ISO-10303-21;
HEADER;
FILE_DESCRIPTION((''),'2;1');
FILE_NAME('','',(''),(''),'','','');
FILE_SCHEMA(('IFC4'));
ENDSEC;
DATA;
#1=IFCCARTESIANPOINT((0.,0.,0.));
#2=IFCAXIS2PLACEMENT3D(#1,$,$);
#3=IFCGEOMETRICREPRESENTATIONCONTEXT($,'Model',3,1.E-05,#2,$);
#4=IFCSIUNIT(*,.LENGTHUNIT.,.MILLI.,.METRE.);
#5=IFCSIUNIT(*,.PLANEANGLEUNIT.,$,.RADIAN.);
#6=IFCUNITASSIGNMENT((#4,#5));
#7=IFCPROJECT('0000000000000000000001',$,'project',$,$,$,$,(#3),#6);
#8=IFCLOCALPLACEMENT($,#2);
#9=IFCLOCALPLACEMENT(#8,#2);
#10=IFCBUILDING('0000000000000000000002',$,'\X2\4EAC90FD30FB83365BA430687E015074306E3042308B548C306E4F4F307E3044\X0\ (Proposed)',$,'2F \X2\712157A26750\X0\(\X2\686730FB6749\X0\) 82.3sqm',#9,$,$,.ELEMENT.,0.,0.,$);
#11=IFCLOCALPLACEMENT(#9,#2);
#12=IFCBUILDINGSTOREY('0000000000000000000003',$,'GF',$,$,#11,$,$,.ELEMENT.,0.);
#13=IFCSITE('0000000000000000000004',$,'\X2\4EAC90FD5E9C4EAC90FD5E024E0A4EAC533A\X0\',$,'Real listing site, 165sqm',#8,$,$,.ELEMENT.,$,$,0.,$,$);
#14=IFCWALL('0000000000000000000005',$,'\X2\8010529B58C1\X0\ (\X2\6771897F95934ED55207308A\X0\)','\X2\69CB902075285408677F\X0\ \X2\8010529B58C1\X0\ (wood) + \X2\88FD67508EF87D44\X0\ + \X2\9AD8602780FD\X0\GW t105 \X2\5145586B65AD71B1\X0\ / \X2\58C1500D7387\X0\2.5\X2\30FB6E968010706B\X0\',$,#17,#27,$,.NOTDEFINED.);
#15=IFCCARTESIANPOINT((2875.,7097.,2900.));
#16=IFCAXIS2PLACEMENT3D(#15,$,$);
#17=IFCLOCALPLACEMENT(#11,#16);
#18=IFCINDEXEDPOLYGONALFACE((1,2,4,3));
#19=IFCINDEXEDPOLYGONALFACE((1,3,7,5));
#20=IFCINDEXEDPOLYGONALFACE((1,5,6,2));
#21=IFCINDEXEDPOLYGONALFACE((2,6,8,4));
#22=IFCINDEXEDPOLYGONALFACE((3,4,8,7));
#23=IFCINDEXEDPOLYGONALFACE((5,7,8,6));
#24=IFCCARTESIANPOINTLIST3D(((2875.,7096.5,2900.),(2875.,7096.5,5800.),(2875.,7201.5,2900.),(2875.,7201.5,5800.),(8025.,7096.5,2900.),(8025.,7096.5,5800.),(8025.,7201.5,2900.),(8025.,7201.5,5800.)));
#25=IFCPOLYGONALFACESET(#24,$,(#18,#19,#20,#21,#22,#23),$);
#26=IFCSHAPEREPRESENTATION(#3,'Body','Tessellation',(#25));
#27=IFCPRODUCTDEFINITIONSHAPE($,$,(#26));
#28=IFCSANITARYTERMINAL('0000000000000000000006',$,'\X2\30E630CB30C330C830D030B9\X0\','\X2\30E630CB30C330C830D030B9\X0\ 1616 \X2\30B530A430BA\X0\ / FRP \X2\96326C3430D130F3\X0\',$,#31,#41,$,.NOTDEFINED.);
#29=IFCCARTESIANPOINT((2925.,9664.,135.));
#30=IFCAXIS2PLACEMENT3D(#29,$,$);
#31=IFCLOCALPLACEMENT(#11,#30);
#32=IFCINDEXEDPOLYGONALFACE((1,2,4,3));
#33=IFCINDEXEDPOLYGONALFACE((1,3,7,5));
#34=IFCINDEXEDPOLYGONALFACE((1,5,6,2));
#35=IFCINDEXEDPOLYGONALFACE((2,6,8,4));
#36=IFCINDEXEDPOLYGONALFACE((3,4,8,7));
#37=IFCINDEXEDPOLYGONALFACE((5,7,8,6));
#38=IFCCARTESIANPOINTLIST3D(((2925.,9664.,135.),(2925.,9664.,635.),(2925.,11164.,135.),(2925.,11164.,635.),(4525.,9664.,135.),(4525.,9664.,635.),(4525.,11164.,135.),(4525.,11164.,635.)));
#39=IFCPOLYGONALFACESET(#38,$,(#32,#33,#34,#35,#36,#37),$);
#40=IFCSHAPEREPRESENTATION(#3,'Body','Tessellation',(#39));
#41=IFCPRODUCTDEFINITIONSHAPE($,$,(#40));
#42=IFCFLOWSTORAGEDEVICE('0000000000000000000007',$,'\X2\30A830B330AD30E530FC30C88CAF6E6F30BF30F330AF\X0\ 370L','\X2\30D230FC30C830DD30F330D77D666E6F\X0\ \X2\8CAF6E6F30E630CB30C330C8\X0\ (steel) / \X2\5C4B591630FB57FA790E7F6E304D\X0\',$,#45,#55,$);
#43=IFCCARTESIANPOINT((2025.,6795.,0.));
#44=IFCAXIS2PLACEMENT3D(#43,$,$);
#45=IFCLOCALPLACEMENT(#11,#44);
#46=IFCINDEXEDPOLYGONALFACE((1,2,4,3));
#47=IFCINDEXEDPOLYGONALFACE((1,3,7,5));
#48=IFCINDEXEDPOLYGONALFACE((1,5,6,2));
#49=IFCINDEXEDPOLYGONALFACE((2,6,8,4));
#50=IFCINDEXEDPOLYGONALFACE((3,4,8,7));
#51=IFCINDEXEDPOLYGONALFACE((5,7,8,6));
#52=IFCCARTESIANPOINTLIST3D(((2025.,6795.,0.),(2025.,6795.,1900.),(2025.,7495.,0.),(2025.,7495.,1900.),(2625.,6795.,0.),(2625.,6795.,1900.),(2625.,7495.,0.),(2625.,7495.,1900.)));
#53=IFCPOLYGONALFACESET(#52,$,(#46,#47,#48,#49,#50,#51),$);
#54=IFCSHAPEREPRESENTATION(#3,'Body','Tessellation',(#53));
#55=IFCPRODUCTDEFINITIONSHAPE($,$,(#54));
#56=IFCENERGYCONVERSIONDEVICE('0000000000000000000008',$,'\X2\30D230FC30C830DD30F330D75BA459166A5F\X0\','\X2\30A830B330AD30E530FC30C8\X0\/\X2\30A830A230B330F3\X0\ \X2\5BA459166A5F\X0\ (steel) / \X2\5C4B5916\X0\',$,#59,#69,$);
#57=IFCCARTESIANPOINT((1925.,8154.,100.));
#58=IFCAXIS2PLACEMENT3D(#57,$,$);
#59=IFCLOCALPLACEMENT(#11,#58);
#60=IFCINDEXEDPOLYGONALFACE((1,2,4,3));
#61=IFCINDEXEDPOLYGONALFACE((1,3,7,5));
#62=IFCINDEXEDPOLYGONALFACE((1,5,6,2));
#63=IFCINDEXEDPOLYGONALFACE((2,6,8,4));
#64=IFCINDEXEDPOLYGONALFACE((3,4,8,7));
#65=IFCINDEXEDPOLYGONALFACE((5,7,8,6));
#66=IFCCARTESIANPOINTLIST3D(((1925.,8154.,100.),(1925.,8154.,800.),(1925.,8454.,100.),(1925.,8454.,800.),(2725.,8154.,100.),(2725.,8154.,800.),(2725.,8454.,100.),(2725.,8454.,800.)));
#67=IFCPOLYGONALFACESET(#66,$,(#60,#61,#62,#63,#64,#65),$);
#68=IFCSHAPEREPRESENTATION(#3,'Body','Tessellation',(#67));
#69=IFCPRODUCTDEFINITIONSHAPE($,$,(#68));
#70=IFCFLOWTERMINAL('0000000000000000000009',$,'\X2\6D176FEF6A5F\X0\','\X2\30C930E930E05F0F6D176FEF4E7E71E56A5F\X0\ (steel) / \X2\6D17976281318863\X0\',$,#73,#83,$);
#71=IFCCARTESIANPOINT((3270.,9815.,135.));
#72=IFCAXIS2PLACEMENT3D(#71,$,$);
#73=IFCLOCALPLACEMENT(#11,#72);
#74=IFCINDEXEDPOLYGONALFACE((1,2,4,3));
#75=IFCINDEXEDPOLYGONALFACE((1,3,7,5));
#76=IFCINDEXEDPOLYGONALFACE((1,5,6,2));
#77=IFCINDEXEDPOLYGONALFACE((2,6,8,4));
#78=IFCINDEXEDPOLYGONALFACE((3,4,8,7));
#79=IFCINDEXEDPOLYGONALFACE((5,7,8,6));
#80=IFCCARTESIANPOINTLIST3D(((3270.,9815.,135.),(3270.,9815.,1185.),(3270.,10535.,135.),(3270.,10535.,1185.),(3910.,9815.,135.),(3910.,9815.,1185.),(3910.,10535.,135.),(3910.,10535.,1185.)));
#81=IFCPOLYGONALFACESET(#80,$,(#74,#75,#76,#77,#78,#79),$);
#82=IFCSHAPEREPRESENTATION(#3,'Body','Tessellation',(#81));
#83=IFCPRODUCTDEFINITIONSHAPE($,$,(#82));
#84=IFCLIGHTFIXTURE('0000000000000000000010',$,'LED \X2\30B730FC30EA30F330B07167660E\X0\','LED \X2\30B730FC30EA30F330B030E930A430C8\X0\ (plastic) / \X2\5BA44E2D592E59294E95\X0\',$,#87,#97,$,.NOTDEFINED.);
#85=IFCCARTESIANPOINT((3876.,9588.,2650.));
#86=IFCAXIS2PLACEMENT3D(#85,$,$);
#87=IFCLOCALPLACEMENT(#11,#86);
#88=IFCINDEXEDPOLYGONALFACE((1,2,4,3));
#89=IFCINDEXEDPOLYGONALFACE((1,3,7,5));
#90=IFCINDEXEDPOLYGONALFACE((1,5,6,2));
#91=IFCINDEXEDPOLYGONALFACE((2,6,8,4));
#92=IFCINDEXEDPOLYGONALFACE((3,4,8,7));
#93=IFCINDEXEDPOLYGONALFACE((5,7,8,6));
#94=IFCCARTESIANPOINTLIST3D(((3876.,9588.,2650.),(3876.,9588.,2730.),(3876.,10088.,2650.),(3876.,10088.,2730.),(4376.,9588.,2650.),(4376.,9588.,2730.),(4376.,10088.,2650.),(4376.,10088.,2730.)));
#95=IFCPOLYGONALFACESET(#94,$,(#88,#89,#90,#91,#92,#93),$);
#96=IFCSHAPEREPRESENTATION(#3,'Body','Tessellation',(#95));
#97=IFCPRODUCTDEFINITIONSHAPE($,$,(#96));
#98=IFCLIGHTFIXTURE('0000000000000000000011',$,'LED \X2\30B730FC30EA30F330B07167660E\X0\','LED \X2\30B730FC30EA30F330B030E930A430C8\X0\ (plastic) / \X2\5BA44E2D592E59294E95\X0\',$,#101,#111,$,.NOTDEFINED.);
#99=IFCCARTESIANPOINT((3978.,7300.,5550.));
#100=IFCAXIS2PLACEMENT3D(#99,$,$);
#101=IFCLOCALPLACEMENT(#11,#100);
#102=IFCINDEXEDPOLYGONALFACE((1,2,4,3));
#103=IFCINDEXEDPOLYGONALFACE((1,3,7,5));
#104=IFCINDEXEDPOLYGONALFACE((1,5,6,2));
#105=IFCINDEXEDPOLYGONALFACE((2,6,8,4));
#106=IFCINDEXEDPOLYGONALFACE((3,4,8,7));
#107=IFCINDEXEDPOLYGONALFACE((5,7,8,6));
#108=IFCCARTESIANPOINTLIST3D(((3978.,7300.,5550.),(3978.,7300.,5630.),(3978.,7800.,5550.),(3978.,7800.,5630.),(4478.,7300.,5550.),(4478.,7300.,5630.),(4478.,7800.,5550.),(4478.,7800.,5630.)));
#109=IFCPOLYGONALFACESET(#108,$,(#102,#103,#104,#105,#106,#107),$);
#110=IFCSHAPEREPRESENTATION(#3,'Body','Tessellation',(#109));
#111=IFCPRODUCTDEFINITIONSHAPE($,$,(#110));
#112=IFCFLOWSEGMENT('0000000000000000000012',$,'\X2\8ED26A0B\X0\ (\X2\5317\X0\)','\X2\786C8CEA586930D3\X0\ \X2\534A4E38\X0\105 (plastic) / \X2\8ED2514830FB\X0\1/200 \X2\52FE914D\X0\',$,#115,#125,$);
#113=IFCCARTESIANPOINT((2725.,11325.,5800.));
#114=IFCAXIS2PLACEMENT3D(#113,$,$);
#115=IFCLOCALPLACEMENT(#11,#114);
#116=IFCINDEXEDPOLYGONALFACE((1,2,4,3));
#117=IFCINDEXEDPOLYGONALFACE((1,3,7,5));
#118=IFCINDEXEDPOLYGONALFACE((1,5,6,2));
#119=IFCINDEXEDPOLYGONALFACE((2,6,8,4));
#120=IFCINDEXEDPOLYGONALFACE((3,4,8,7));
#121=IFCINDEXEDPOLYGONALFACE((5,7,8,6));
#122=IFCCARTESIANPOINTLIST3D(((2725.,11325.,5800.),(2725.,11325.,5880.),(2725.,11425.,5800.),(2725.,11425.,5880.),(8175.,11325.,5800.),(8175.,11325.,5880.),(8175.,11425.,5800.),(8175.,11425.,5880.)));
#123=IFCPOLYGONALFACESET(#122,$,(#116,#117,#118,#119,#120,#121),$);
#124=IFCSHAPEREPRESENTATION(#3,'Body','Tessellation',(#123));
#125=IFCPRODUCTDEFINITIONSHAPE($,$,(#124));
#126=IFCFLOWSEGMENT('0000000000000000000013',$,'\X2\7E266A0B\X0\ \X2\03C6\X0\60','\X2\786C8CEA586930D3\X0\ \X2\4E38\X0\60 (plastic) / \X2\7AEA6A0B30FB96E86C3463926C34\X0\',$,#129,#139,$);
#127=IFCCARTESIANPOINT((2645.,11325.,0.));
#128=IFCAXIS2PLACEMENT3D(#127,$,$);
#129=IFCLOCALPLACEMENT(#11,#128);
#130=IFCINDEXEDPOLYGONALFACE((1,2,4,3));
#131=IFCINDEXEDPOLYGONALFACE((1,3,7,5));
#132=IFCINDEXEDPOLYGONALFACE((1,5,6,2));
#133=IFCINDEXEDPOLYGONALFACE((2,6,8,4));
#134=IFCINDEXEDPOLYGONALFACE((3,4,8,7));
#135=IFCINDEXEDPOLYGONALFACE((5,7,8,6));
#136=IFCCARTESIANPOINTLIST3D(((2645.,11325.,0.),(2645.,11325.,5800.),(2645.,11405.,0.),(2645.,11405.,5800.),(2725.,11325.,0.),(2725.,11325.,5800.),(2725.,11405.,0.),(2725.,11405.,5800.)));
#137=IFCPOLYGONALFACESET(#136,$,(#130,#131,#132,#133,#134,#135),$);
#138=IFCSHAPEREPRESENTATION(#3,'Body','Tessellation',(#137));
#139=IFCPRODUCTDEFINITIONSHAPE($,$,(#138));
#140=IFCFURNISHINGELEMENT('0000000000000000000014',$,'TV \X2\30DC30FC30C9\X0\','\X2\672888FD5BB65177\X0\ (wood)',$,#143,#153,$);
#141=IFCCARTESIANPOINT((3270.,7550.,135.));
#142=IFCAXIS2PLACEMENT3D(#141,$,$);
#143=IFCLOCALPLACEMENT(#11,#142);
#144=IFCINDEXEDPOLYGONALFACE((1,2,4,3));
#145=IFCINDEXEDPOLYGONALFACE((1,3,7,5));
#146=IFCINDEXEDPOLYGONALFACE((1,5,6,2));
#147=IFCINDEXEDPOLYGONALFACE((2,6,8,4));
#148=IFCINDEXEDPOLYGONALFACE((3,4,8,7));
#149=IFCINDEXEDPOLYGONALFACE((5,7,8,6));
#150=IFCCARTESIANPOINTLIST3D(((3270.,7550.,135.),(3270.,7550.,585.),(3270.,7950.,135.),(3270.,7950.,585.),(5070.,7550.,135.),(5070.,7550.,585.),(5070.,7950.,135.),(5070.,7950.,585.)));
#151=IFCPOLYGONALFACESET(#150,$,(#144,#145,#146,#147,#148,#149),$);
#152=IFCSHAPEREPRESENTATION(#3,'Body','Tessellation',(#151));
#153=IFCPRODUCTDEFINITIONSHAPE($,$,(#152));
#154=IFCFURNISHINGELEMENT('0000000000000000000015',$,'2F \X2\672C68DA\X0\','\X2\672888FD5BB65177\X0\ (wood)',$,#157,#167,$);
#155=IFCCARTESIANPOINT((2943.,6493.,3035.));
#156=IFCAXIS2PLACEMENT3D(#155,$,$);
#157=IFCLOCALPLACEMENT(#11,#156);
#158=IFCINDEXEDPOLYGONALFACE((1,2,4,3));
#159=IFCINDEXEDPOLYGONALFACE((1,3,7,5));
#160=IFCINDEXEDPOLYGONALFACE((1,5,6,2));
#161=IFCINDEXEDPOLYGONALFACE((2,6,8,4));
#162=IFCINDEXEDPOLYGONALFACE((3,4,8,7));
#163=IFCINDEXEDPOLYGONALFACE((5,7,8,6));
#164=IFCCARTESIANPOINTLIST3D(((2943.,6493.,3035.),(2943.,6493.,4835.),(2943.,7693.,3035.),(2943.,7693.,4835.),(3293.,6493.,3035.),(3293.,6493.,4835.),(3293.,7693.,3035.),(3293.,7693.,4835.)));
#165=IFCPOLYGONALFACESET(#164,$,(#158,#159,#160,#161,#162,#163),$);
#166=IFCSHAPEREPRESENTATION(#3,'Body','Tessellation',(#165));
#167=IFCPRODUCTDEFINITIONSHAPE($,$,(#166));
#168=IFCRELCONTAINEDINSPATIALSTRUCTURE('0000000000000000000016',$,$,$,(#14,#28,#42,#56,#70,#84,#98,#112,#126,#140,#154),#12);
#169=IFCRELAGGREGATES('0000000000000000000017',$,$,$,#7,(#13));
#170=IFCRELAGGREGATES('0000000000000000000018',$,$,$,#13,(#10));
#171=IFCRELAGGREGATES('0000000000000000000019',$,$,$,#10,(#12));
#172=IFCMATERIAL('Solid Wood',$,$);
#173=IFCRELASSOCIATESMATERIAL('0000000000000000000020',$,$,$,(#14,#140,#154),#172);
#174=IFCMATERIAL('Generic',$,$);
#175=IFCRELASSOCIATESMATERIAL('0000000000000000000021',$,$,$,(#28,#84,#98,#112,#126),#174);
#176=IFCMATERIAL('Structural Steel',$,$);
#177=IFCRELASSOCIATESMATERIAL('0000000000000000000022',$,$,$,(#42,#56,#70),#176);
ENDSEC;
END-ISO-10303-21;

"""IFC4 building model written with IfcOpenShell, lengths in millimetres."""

from ifc_helpers import new_model, si_unit, frame, frame_2d, origin, place, context, project, spatial, rectangle, extrude, material, element, save


model = new_model("IFC4")

# Units and contexts
model_context = context("Model", 3, precision=1e-05, world=origin())
ifc_project = project(units=[si_unit("LENGTHUNIT", "METRE", prefix="MILLI"), si_unit("PLANEANGLEUNIT", "RADIAN")], contexts=[model_context])

# Site, building, storey
site_placement = place(None, origin())
site = spatial("IfcSite", under=ifc_project, at=site_placement, Name="京都府京都市上京区", ObjectType="Real listing site, 165sqm", CompositionType="ELEMENT", RefElevation=0.0)
building_placement = place(site_placement, origin())
building = spatial("IfcBuilding", under=site, at=building_placement, Name="京都・茶室と縁側のある和の住まい (Proposed)", ObjectType="2F 無垢材(桧・杉) 82.3sqm", CompositionType="ELEMENT", ElevationOfRefHeight=0.0, ElevationOfTerrain=0.0)
storey_placement = place(building_placement, origin())
storey = spatial("IfcBuildingStorey", under=building, at=storey_placement, Name="GF", CompositionType="ELEMENT", Elevation=0.0)

# Shared definitions
ifc_material_1 = material(Name="Solid Wood")

# Wall
wall_1_placement = place(storey_placement, frame((2875.0, 7097.0, 2900.0)))
element("IfcWall", 1, at=wall_1_placement, inside=storey, material=ifc_material_1, Name="耐力壁 (東西間仕切り)", Description="構造用合板 耐力壁 (wood) + 製材軸組 + 高性能GW t105 充填断熱 / 壁倍率2.5・準耐火", PredefinedType="NOTDEFINED", context=model_context, shape_type="SweptSolid", body=[
    extrude(rectangle(XDim=5150.0, YDim=105.0, at=frame_2d((2575.0, 52.0))), frame((2875.0, 7097.0, 2900.0)), (0.0, 0.0, 1.0), 2900.0),
])

# Sanitary terminal
ifc_material_2 = material(Name="Generic")
sanitary_terminal_placement = place(storey_placement, frame((2925.0, 9664.0, 135.0)))
element("IfcSanitaryTerminal", 2, at=sanitary_terminal_placement, inside=storey, material=ifc_material_2, Name="ユニットバス", Description="ユニットバス 1616 サイズ / FRP 防水パン", PredefinedType="NOTDEFINED", context=model_context, shape_type="SweptSolid", body=[
    extrude(rectangle(XDim=1600.0, YDim=1500.0, at=frame_2d((800.0, 750.0))), frame((2925.0, 9664.0, 135.0)), (0.0, 0.0, 1.0), 500.0),
])

# Flow storage device
ifc_material_3 = material(Name="Structural Steel")
flow_storage_device_placement = place(storey_placement, frame((2025.0, 6795.0, 0.0)))
element("IfcFlowStorageDevice", 3, at=flow_storage_device_placement, inside=storey, material=ifc_material_3, Name="エコキュート貯湯タンク 370L", Description="ヒートポンプ給湯 貯湯ユニット (steel) / 屋外・基礎置き", context=model_context, shape_type="SweptSolid", body=[
    extrude(rectangle(XDim=600.0, YDim=700.0, at=frame_2d((300.0, 350.0))), frame((2025.0, 6795.0, 0.0)), (0.0, 0.0, 1.0), 1900.0),
])

# Energy conversion device
energy_conversion_device_placement = place(storey_placement, frame((1925.0, 8154.0, 100.0)))
element("IfcEnergyConversionDevice", 4, at=energy_conversion_device_placement, inside=storey, material=ifc_material_3, Name="ヒートポンプ室外機", Description="エコキュート/エアコン 室外機 (steel) / 屋外", context=model_context, shape_type="SweptSolid", body=[
    extrude(rectangle(XDim=800.0, YDim=300.0, at=frame_2d((400.0, 150.0))), frame((1925.0, 8154.0, 100.0)), (0.0, 0.0, 1.0), 700.0),
])

# Flow terminal
flow_terminal_placement = place(storey_placement, frame((3270.0, 9815.0, 135.0)))
element("IfcFlowTerminal", 5, at=flow_terminal_placement, inside=storey, material=ifc_material_3, Name="洗濯機", Description="ドラム式洗濯乾燥機 (steel) / 洗面脱衣", context=model_context, shape_type="SweptSolid", body=[
    extrude(rectangle(XDim=640.0, YDim=720.0, at=frame_2d((320.0, 360.0))), frame((3270.0, 9815.0, 135.0)), (0.0, 0.0, 1.0), 1050.0),
])

# Light fixtures
light_fixture_1_placement = place(storey_placement, frame((3876.0, 9588.0, 2650.0)))
element("IfcLightFixture", 6, at=light_fixture_1_placement, inside=storey, material=ifc_material_2, Name="LED シーリング照明", Description="LED シーリングライト (plastic) / 室中央天井", PredefinedType="NOTDEFINED", context=model_context, shape_type="SweptSolid", body=[
    extrude(rectangle(XDim=500.0, YDim=500.0, at=frame_2d((250.0, 250.0))), frame((3876.0, 9588.0, 2650.0)), (0.0, 0.0, 1.0), 80.0),
])
light_fixture_2_placement = place(storey_placement, frame((3978.0, 7300.0, 5550.0)))
element("IfcLightFixture", 7, at=light_fixture_2_placement, inside=storey, material=ifc_material_2, Name="LED シーリング照明", Description="LED シーリングライト (plastic) / 室中央天井", PredefinedType="NOTDEFINED", context=model_context, shape_type="SweptSolid", body=[
    extrude(rectangle(XDim=500.0, YDim=500.0, at=frame_2d((250.0, 250.0))), frame((3978.0, 7300.0, 5550.0)), (0.0, 0.0, 1.0), 80.0),
])

# Flow segments
flow_segment_1_placement = place(storey_placement, frame((2725.0, 11325.0, 5800.0)))
element("IfcFlowSegment", 8, at=flow_segment_1_placement, inside=storey, material=ifc_material_2, Name="軒樋 (北)", Description="硬質塩ビ 半丸105 (plastic) / 軒先・1/200 勾配", context=model_context, shape_type="SweptSolid", body=[
    extrude(rectangle(XDim=5450.0, YDim=100.0, at=frame_2d((2725.0, 50.0))), frame((2725.0, 11325.0, 5800.0)), (0.0, 0.0, 1.0), 80.0),
])
flow_segment_2_placement = place(storey_placement, frame((2645.0, 11325.0, 0.0)))
element("IfcFlowSegment", 9, at=flow_segment_2_placement, inside=storey, material=ifc_material_2, Name="縦樋 φ60", Description="硬質塩ビ 丸60 (plastic) / 竪樋・雨水排水", context=model_context, shape_type="SweptSolid", body=[
    extrude(rectangle(XDim=80.0, YDim=80.0, at=frame_2d((40.0, 40.0))), frame((2645.0, 11325.0, 0.0)), (0.0, 0.0, 1.0), 5800.0),
])

# Furnishing elements
furnishing_1_placement = place(storey_placement, frame((3270.0, 7550.0, 135.0)))
element("IfcFurnishingElement", 10, at=furnishing_1_placement, inside=storey, material=ifc_material_1, Name="TV ボード", Description="木製家具 (wood)", context=model_context, shape_type="SweptSolid", body=[
    extrude(rectangle(XDim=1800.0, YDim=400.0, at=frame_2d((900.0, 200.0))), frame((3270.0, 7550.0, 135.0)), (0.0, 0.0, 1.0), 450.0),
])
furnishing_2_placement = place(storey_placement, frame((2943.0, 6493.0, 3035.0)))
element("IfcFurnishingElement", 11, at=furnishing_2_placement, inside=storey, material=ifc_material_1, Name="2F 本棚", Description="木製家具 (wood)", context=model_context, shape_type="SweptSolid", body=[
    extrude(rectangle(XDim=350.0, YDim=1200.0, at=frame_2d((175.0, 600.0))), frame((2943.0, 6493.0, 3035.0)), (0.0, 0.0, 1.0), 1800.0),
])

save(model, "model.ifc")
